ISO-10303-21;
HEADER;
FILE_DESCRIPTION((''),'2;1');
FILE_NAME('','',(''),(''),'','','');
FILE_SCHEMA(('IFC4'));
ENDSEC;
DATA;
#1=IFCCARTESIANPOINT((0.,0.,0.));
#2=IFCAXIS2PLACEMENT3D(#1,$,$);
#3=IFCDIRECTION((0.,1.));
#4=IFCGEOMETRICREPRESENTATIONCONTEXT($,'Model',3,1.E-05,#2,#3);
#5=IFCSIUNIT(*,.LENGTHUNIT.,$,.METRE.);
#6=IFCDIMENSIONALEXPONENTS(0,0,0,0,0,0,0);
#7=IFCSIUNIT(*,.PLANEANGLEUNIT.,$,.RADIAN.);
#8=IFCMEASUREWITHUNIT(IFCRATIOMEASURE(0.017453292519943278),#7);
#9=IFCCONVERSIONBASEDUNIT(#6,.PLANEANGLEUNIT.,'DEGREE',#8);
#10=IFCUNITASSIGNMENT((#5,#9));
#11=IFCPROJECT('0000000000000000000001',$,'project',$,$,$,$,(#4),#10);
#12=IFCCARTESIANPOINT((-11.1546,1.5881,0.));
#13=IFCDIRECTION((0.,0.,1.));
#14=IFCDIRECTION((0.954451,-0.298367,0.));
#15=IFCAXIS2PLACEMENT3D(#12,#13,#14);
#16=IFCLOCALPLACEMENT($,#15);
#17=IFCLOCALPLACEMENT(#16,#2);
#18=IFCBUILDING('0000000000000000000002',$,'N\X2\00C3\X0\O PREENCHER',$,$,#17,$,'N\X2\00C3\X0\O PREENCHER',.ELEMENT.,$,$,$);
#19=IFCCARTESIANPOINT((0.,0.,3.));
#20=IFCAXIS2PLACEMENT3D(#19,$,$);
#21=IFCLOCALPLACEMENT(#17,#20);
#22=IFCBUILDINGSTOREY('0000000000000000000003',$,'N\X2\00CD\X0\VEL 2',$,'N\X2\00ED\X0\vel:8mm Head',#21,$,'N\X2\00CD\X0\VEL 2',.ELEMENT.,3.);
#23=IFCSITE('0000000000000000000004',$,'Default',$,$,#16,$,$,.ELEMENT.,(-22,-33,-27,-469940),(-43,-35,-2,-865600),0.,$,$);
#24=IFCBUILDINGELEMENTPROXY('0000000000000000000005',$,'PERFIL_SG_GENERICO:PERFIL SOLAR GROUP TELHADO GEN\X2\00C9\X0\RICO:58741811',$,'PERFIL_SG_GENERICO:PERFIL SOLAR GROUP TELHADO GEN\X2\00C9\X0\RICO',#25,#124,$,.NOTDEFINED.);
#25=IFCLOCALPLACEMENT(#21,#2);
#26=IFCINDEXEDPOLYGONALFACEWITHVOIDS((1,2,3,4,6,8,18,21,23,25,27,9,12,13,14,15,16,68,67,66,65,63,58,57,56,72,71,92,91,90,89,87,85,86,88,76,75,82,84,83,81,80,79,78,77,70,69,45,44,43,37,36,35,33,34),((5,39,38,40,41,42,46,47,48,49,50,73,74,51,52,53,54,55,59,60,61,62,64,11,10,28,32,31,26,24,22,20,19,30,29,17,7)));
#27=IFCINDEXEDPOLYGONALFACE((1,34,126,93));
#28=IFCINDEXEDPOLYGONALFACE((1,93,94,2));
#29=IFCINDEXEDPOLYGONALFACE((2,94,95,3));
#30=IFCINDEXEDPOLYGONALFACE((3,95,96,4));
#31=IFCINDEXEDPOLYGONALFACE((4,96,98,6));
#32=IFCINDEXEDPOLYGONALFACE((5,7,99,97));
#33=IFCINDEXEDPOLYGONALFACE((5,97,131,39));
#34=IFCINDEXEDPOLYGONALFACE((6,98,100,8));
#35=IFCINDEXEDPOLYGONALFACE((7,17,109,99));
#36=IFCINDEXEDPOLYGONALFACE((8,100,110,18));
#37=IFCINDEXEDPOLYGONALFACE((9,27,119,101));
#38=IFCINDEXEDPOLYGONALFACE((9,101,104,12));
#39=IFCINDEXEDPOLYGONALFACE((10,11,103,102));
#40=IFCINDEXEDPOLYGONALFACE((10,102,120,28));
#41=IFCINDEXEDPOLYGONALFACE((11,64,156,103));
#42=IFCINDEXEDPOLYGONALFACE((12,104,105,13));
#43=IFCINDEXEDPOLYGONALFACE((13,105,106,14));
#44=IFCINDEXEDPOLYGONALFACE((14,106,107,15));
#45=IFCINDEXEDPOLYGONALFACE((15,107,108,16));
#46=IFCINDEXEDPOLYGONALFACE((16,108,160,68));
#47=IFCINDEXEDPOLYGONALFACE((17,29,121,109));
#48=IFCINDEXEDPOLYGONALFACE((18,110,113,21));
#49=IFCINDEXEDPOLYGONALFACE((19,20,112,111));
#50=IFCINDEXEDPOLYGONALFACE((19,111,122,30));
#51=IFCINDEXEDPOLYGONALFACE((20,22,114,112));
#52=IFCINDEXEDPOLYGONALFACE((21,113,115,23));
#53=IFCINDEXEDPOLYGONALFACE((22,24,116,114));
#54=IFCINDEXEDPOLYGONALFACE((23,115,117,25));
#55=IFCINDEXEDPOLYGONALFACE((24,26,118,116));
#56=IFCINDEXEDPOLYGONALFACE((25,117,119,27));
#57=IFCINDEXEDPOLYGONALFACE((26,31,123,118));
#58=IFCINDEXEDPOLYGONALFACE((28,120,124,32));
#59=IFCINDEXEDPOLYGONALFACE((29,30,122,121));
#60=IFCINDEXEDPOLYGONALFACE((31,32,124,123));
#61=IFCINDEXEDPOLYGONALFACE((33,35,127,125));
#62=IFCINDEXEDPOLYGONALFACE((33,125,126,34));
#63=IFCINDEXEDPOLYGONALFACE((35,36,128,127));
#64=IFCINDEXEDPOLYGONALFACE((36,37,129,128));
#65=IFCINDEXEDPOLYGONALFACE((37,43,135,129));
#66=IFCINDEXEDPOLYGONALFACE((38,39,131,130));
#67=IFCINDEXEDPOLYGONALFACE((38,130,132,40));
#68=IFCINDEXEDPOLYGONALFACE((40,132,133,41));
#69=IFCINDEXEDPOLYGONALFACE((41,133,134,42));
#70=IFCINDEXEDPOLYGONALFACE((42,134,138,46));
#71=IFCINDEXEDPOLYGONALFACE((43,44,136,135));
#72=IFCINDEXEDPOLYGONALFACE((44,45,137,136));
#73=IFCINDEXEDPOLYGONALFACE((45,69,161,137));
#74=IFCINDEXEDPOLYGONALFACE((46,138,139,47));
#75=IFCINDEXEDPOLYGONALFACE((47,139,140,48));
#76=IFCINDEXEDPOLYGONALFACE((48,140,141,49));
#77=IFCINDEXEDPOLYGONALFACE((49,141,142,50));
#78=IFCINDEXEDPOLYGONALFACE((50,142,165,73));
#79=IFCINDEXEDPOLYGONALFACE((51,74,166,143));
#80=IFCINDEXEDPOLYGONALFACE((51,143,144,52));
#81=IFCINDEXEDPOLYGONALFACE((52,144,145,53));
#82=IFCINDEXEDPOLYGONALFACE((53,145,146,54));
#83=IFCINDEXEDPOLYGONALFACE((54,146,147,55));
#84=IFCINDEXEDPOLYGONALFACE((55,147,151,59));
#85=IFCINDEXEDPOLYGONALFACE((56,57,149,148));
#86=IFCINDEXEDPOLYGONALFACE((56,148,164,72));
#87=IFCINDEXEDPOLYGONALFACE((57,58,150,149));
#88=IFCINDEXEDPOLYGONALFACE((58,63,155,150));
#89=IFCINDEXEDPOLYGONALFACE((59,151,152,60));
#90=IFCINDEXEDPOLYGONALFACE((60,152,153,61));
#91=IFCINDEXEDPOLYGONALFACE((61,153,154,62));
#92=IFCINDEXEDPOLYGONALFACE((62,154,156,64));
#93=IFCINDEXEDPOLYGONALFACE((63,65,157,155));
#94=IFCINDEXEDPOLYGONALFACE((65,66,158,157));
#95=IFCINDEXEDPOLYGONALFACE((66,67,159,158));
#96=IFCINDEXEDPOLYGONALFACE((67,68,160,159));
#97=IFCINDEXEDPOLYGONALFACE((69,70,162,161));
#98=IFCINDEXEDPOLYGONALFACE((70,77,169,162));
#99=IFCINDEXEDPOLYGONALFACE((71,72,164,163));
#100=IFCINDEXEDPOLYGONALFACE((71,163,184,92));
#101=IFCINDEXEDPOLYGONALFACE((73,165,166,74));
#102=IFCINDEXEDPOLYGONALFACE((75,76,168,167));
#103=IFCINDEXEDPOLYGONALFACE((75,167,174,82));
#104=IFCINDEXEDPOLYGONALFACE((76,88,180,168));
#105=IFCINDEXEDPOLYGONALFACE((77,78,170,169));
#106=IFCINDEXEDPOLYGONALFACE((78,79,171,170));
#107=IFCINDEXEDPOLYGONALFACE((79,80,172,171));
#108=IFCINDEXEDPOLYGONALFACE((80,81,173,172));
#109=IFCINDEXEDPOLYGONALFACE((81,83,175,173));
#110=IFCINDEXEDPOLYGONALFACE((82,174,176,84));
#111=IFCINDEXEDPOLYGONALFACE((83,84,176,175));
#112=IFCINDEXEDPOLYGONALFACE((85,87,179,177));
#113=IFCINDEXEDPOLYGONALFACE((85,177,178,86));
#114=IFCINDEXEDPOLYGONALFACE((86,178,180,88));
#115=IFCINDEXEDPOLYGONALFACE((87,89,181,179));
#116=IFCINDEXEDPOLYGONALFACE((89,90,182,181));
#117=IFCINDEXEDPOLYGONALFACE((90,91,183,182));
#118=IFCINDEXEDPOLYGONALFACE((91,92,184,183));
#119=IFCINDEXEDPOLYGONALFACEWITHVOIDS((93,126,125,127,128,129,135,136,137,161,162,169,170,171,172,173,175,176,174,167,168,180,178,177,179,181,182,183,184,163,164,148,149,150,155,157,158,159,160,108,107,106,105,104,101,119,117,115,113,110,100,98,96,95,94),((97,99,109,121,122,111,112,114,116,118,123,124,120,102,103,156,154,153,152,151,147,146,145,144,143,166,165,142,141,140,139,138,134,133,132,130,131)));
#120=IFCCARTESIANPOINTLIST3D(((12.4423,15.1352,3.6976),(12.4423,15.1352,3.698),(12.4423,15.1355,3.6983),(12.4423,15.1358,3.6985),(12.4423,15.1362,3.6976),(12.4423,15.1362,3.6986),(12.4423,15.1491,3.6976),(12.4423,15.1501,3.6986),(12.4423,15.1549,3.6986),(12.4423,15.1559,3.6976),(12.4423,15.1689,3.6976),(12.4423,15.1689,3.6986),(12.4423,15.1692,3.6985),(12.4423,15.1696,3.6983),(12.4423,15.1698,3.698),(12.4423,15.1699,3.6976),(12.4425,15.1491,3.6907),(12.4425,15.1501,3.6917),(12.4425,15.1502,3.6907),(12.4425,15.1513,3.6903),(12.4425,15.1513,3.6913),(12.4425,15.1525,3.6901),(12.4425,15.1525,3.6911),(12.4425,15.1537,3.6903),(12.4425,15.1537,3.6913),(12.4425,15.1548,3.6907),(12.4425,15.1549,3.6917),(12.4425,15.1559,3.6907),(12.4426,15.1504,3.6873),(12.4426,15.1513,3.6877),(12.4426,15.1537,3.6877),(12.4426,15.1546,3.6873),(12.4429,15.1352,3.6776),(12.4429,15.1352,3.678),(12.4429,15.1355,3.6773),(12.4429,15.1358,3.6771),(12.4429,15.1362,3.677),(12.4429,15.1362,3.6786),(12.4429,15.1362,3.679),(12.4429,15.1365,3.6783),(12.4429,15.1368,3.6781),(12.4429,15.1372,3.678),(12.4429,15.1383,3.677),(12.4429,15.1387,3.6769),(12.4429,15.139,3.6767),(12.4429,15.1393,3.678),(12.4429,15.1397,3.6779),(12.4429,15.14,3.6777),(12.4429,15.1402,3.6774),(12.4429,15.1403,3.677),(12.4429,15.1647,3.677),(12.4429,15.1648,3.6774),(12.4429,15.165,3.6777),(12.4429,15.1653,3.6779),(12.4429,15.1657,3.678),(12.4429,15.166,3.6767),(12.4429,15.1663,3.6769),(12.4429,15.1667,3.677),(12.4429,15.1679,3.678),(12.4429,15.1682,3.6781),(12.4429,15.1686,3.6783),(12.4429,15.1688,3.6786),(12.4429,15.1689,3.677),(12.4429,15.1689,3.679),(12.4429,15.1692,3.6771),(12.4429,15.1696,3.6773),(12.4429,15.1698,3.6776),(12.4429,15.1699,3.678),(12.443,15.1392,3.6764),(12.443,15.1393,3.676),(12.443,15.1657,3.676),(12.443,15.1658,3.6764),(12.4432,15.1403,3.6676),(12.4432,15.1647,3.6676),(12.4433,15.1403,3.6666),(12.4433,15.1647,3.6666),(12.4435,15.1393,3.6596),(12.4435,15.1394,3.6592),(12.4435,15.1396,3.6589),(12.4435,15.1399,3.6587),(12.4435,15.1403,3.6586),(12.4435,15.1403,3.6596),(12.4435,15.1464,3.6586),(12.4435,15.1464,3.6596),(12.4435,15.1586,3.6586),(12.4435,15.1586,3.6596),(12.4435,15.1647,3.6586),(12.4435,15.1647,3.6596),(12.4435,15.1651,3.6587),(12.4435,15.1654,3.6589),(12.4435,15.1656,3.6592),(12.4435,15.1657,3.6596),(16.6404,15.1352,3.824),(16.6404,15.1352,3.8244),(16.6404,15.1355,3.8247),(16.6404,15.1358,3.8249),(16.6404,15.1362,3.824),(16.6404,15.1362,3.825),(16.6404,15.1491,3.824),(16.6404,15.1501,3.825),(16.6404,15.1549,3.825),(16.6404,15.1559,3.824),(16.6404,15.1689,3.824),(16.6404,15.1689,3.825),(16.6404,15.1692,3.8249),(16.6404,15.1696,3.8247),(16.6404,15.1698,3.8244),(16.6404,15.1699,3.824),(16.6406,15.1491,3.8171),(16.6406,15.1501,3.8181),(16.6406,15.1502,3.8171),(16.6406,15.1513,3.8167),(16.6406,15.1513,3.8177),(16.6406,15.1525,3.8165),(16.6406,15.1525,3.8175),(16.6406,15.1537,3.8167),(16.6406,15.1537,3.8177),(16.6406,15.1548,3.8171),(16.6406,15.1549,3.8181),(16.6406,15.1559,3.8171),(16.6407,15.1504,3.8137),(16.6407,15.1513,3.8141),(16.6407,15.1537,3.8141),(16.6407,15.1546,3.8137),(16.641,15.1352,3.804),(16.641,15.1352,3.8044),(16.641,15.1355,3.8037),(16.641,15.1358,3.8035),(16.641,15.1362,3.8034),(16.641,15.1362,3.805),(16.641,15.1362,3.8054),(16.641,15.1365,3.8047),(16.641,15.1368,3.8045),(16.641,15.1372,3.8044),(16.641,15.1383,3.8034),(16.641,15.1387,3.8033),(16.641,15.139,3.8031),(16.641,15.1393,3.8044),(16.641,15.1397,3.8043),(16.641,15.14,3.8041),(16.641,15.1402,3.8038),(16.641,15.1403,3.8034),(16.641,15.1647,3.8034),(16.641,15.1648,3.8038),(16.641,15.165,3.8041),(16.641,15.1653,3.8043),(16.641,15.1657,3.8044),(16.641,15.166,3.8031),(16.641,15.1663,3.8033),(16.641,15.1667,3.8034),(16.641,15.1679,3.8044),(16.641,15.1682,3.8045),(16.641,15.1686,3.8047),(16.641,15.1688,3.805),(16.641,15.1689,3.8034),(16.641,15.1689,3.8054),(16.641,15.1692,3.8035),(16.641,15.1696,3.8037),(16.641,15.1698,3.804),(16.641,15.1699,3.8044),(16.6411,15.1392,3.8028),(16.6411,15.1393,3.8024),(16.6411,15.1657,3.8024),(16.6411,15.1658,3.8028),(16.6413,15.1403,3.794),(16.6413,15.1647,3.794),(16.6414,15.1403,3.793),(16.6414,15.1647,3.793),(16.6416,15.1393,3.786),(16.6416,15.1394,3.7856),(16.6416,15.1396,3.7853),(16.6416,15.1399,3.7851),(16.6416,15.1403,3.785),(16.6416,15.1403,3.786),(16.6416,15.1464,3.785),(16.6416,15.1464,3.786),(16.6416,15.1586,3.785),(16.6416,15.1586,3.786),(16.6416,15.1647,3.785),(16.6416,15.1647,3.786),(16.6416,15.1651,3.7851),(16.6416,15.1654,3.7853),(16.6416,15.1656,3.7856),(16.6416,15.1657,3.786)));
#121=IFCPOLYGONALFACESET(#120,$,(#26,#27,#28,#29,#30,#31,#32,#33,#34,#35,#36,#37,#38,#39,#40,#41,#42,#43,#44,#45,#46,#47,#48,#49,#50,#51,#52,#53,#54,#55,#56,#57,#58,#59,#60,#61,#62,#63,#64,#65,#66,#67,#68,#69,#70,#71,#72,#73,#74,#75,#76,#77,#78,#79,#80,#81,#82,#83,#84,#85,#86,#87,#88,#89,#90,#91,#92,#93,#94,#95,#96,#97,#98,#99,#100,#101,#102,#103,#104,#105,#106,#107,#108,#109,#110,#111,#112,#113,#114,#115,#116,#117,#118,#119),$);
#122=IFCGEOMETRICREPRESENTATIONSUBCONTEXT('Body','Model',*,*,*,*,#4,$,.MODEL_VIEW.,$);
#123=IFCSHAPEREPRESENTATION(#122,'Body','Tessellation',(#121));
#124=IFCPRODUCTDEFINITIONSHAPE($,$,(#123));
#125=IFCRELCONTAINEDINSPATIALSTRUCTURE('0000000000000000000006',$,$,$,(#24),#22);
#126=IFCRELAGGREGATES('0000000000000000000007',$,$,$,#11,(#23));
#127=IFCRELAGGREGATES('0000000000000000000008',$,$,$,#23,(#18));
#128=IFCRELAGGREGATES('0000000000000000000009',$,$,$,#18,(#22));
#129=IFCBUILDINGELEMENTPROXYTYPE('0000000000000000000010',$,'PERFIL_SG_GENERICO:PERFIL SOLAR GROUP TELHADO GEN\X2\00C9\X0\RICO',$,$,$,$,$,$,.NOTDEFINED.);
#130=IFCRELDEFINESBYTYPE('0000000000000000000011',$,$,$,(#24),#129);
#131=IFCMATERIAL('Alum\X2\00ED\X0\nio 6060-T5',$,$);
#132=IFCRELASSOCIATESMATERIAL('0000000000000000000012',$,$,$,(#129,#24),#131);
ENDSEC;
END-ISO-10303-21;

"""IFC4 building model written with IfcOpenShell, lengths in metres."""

from ifc_helpers import new_model, entity, si_unit, converted_unit, direction, frame, origin, place, context, subcontext, project, spatial, line, arc, indexed_curve, outline, extrude, source, transform, mapped, material, type_object, type_shapes, element, save


model = new_model("IFC4")

# Units and contexts
model_context = context("Model", 3, precision=1e-05, world=origin(), true_north=direction((0.0, 1.0)))
body_context = subcontext(model_context, "Body", "Model", "MODEL_VIEW")
ifc_project = project(units=[si_unit("LENGTHUNIT", "METRE"), converted_unit("PLANEANGLEUNIT", "DEGREE", entity("IfcRatioMeasure", 0.017453292519943278), si_unit("PLANEANGLEUNIT", "RADIAN"), dimensions=[0, 0, 0, 0, 0, 0, 0])], contexts=[model_context])

# Site, building, storey
site_placement = place(None, frame((-11.1546, 1.5881, 0.0), z_axis=(0.0, 0.0, 1.0), x_axis=(0.954451, -0.298367, 0.0)))
site = spatial("IfcSite", under=ifc_project, at=site_placement, Name="Default", CompositionType="ELEMENT", RefLatitude=(-22, -33, -27, -469940), RefLongitude=(-43, -35, -2, -865600), RefElevation=0.0)
building_placement = place(site_placement, origin())
building = spatial("IfcBuilding", under=site, at=building_placement, Name="NÃO PREENCHER", LongName="NÃO PREENCHER", CompositionType="ELEMENT")
storey_placement = place(building_placement, frame((0.0, 0.0, 3.0)))
storey = spatial("IfcBuildingStorey", under=building, at=storey_placement, Name="NÍVEL 2", ObjectType="Nível:8mm Head", LongName="NÍVEL 2", CompositionType="ELEMENT", Elevation=3.0)

# Building element proxy
ifc_material_1 = material(Name="Alumínio 6060-T5")
building_element_proxy_type_1 = type_object("IfcBuildingElementProxyType", Name="PERFIL_SG_GENERICO:PERFIL SOLAR GROUP TELHADO GENÉRICO", PredefinedType="NOTDEFINED", material=ifc_material_1)
shared_shape_1 = source(origin(), body_context, "Body", "SweptSolid", [
    extrude(outline(indexed_curve([(-0.0122, -0.0169), (-0.0061, -0.0169), (-0.0061, -0.0159), (-0.0122, -0.0159), (-0.0122, -0.0089), (0.0122, -0.0089), (0.0122, -0.0159), (0.0061, -0.0159), (0.0061, -0.0169), (0.0122, -0.0169), (0.0129, -0.0166), (0.0132, -0.0159), (0.0132, 0.0005), (0.0135, 0.0012), (0.0142, 0.0015), (0.0164, 0.0015), (0.0171, 0.0018), (0.0174, 0.0025), (0.0174, 0.0221), (0.0171, 0.0228), (0.0164, 0.0231), (0.0024, 0.0231), (0.0024, 0.0162), (0.0, 0.0156), (-0.0024, 0.0162), (-0.0024, 0.0231), (-0.0164, 0.0231), (-0.0171, 0.0228), (-0.0174, 0.0221), (-0.0174, 0.0025), (-0.0171, 0.0018), (-0.0164, 0.0015), (-0.0142, 0.0015), (-0.0135, 0.0012), (-0.0132, 0.0005), (-0.0132, -0.0159), (-0.0129, -0.0166)], segments=[line(1, 2, 3, 4, 5, 6, 7, 8, 9, 10), arc(10, 11, 12), line(12, 13), arc(13, 14, 15), line(15, 16), arc(16, 17, 18), line(18, 19), arc(19, 20, 21), line(21, 22, 23), arc(23, 24, 25), line(25, 26, 27), arc(27, 28, 29), line(29, 30), arc(30, 31, 32), line(32, 33), arc(33, 34, 35), line(35, 36), arc(36, 37, 1)], self_intersect=False), holes=[indexed_curve([(-0.0122, -0.0079), (-0.0122, 0.0015), (-0.0125, 0.0022), (-0.0132, 0.0025), (-0.0154, 0.0025), (-0.0161, 0.0028), (-0.0164, 0.0035), (-0.0164, 0.0221), (-0.0034, 0.0221), (-0.0034, 0.0152), (-0.0021, 0.0118), (-0.0012, 0.0122), (-0.0023, 0.0151), (0.0, 0.0146), (0.0023, 0.0151), (0.0012, 0.0122), (0.0021, 0.0118), (0.0034, 0.0152), (0.0034, 0.0221), (0.0164, 0.0221), (0.0164, 0.0035), (0.0161, 0.0028), (0.0154, 0.0025), (0.0132, 0.0025), (0.0125, 0.0022), (0.0122, 0.0015), (0.0122, -0.0079)], segments=[line(1, 2), arc(2, 3, 4), line(4, 5), arc(5, 6, 7), line(7, 8, 9, 10, 11, 12, 13), arc(13, 14, 15), line(15, 16, 17, 18, 19, 20, 21), arc(21, 22, 23), line(23, 24), arc(24, 25, 26), line(26, 27, 1)], self_intersect=False)]), frame((0.0, 0.0, 0.0169), z_axis=(1.0, 0.0, 0.0), x_axis=(0.0, 1.0, 0.0)), (0.0, 0.0, 1.0), 4.2),
])
type_shapes(building_element_proxy_type_1, [shared_shape_1])
for number, where, z_axis, x_axis, name in (
    (1, (12.4435, 15.1525, 3.6586), (-0.030095, 0.0, 0.999547), (0.999547, 0.0, 0.030095), "PERFIL_SG_GENERICO:PERFIL SOLAR GROUP TELHADO GENÉRICO:58741811"),
):
    element("IfcBuildingElementProxy", number, at=place(storey_placement, frame(where, z_axis=z_axis, x_axis=x_axis)), inside=storey, type_object=building_element_proxy_type_1, material=ifc_material_1, Name=name, ObjectType="PERFIL_SG_GENERICO:PERFIL SOLAR GROUP TELHADO GENÉRICO", PredefinedType="NOTDEFINED", context=body_context, shape_type="MappedRepresentation", body=[
        mapped(shared_shape_1, transform((0.0, 0.0, 0.0), scale=1.0)),
    ])

save(model, "model.ifc")
